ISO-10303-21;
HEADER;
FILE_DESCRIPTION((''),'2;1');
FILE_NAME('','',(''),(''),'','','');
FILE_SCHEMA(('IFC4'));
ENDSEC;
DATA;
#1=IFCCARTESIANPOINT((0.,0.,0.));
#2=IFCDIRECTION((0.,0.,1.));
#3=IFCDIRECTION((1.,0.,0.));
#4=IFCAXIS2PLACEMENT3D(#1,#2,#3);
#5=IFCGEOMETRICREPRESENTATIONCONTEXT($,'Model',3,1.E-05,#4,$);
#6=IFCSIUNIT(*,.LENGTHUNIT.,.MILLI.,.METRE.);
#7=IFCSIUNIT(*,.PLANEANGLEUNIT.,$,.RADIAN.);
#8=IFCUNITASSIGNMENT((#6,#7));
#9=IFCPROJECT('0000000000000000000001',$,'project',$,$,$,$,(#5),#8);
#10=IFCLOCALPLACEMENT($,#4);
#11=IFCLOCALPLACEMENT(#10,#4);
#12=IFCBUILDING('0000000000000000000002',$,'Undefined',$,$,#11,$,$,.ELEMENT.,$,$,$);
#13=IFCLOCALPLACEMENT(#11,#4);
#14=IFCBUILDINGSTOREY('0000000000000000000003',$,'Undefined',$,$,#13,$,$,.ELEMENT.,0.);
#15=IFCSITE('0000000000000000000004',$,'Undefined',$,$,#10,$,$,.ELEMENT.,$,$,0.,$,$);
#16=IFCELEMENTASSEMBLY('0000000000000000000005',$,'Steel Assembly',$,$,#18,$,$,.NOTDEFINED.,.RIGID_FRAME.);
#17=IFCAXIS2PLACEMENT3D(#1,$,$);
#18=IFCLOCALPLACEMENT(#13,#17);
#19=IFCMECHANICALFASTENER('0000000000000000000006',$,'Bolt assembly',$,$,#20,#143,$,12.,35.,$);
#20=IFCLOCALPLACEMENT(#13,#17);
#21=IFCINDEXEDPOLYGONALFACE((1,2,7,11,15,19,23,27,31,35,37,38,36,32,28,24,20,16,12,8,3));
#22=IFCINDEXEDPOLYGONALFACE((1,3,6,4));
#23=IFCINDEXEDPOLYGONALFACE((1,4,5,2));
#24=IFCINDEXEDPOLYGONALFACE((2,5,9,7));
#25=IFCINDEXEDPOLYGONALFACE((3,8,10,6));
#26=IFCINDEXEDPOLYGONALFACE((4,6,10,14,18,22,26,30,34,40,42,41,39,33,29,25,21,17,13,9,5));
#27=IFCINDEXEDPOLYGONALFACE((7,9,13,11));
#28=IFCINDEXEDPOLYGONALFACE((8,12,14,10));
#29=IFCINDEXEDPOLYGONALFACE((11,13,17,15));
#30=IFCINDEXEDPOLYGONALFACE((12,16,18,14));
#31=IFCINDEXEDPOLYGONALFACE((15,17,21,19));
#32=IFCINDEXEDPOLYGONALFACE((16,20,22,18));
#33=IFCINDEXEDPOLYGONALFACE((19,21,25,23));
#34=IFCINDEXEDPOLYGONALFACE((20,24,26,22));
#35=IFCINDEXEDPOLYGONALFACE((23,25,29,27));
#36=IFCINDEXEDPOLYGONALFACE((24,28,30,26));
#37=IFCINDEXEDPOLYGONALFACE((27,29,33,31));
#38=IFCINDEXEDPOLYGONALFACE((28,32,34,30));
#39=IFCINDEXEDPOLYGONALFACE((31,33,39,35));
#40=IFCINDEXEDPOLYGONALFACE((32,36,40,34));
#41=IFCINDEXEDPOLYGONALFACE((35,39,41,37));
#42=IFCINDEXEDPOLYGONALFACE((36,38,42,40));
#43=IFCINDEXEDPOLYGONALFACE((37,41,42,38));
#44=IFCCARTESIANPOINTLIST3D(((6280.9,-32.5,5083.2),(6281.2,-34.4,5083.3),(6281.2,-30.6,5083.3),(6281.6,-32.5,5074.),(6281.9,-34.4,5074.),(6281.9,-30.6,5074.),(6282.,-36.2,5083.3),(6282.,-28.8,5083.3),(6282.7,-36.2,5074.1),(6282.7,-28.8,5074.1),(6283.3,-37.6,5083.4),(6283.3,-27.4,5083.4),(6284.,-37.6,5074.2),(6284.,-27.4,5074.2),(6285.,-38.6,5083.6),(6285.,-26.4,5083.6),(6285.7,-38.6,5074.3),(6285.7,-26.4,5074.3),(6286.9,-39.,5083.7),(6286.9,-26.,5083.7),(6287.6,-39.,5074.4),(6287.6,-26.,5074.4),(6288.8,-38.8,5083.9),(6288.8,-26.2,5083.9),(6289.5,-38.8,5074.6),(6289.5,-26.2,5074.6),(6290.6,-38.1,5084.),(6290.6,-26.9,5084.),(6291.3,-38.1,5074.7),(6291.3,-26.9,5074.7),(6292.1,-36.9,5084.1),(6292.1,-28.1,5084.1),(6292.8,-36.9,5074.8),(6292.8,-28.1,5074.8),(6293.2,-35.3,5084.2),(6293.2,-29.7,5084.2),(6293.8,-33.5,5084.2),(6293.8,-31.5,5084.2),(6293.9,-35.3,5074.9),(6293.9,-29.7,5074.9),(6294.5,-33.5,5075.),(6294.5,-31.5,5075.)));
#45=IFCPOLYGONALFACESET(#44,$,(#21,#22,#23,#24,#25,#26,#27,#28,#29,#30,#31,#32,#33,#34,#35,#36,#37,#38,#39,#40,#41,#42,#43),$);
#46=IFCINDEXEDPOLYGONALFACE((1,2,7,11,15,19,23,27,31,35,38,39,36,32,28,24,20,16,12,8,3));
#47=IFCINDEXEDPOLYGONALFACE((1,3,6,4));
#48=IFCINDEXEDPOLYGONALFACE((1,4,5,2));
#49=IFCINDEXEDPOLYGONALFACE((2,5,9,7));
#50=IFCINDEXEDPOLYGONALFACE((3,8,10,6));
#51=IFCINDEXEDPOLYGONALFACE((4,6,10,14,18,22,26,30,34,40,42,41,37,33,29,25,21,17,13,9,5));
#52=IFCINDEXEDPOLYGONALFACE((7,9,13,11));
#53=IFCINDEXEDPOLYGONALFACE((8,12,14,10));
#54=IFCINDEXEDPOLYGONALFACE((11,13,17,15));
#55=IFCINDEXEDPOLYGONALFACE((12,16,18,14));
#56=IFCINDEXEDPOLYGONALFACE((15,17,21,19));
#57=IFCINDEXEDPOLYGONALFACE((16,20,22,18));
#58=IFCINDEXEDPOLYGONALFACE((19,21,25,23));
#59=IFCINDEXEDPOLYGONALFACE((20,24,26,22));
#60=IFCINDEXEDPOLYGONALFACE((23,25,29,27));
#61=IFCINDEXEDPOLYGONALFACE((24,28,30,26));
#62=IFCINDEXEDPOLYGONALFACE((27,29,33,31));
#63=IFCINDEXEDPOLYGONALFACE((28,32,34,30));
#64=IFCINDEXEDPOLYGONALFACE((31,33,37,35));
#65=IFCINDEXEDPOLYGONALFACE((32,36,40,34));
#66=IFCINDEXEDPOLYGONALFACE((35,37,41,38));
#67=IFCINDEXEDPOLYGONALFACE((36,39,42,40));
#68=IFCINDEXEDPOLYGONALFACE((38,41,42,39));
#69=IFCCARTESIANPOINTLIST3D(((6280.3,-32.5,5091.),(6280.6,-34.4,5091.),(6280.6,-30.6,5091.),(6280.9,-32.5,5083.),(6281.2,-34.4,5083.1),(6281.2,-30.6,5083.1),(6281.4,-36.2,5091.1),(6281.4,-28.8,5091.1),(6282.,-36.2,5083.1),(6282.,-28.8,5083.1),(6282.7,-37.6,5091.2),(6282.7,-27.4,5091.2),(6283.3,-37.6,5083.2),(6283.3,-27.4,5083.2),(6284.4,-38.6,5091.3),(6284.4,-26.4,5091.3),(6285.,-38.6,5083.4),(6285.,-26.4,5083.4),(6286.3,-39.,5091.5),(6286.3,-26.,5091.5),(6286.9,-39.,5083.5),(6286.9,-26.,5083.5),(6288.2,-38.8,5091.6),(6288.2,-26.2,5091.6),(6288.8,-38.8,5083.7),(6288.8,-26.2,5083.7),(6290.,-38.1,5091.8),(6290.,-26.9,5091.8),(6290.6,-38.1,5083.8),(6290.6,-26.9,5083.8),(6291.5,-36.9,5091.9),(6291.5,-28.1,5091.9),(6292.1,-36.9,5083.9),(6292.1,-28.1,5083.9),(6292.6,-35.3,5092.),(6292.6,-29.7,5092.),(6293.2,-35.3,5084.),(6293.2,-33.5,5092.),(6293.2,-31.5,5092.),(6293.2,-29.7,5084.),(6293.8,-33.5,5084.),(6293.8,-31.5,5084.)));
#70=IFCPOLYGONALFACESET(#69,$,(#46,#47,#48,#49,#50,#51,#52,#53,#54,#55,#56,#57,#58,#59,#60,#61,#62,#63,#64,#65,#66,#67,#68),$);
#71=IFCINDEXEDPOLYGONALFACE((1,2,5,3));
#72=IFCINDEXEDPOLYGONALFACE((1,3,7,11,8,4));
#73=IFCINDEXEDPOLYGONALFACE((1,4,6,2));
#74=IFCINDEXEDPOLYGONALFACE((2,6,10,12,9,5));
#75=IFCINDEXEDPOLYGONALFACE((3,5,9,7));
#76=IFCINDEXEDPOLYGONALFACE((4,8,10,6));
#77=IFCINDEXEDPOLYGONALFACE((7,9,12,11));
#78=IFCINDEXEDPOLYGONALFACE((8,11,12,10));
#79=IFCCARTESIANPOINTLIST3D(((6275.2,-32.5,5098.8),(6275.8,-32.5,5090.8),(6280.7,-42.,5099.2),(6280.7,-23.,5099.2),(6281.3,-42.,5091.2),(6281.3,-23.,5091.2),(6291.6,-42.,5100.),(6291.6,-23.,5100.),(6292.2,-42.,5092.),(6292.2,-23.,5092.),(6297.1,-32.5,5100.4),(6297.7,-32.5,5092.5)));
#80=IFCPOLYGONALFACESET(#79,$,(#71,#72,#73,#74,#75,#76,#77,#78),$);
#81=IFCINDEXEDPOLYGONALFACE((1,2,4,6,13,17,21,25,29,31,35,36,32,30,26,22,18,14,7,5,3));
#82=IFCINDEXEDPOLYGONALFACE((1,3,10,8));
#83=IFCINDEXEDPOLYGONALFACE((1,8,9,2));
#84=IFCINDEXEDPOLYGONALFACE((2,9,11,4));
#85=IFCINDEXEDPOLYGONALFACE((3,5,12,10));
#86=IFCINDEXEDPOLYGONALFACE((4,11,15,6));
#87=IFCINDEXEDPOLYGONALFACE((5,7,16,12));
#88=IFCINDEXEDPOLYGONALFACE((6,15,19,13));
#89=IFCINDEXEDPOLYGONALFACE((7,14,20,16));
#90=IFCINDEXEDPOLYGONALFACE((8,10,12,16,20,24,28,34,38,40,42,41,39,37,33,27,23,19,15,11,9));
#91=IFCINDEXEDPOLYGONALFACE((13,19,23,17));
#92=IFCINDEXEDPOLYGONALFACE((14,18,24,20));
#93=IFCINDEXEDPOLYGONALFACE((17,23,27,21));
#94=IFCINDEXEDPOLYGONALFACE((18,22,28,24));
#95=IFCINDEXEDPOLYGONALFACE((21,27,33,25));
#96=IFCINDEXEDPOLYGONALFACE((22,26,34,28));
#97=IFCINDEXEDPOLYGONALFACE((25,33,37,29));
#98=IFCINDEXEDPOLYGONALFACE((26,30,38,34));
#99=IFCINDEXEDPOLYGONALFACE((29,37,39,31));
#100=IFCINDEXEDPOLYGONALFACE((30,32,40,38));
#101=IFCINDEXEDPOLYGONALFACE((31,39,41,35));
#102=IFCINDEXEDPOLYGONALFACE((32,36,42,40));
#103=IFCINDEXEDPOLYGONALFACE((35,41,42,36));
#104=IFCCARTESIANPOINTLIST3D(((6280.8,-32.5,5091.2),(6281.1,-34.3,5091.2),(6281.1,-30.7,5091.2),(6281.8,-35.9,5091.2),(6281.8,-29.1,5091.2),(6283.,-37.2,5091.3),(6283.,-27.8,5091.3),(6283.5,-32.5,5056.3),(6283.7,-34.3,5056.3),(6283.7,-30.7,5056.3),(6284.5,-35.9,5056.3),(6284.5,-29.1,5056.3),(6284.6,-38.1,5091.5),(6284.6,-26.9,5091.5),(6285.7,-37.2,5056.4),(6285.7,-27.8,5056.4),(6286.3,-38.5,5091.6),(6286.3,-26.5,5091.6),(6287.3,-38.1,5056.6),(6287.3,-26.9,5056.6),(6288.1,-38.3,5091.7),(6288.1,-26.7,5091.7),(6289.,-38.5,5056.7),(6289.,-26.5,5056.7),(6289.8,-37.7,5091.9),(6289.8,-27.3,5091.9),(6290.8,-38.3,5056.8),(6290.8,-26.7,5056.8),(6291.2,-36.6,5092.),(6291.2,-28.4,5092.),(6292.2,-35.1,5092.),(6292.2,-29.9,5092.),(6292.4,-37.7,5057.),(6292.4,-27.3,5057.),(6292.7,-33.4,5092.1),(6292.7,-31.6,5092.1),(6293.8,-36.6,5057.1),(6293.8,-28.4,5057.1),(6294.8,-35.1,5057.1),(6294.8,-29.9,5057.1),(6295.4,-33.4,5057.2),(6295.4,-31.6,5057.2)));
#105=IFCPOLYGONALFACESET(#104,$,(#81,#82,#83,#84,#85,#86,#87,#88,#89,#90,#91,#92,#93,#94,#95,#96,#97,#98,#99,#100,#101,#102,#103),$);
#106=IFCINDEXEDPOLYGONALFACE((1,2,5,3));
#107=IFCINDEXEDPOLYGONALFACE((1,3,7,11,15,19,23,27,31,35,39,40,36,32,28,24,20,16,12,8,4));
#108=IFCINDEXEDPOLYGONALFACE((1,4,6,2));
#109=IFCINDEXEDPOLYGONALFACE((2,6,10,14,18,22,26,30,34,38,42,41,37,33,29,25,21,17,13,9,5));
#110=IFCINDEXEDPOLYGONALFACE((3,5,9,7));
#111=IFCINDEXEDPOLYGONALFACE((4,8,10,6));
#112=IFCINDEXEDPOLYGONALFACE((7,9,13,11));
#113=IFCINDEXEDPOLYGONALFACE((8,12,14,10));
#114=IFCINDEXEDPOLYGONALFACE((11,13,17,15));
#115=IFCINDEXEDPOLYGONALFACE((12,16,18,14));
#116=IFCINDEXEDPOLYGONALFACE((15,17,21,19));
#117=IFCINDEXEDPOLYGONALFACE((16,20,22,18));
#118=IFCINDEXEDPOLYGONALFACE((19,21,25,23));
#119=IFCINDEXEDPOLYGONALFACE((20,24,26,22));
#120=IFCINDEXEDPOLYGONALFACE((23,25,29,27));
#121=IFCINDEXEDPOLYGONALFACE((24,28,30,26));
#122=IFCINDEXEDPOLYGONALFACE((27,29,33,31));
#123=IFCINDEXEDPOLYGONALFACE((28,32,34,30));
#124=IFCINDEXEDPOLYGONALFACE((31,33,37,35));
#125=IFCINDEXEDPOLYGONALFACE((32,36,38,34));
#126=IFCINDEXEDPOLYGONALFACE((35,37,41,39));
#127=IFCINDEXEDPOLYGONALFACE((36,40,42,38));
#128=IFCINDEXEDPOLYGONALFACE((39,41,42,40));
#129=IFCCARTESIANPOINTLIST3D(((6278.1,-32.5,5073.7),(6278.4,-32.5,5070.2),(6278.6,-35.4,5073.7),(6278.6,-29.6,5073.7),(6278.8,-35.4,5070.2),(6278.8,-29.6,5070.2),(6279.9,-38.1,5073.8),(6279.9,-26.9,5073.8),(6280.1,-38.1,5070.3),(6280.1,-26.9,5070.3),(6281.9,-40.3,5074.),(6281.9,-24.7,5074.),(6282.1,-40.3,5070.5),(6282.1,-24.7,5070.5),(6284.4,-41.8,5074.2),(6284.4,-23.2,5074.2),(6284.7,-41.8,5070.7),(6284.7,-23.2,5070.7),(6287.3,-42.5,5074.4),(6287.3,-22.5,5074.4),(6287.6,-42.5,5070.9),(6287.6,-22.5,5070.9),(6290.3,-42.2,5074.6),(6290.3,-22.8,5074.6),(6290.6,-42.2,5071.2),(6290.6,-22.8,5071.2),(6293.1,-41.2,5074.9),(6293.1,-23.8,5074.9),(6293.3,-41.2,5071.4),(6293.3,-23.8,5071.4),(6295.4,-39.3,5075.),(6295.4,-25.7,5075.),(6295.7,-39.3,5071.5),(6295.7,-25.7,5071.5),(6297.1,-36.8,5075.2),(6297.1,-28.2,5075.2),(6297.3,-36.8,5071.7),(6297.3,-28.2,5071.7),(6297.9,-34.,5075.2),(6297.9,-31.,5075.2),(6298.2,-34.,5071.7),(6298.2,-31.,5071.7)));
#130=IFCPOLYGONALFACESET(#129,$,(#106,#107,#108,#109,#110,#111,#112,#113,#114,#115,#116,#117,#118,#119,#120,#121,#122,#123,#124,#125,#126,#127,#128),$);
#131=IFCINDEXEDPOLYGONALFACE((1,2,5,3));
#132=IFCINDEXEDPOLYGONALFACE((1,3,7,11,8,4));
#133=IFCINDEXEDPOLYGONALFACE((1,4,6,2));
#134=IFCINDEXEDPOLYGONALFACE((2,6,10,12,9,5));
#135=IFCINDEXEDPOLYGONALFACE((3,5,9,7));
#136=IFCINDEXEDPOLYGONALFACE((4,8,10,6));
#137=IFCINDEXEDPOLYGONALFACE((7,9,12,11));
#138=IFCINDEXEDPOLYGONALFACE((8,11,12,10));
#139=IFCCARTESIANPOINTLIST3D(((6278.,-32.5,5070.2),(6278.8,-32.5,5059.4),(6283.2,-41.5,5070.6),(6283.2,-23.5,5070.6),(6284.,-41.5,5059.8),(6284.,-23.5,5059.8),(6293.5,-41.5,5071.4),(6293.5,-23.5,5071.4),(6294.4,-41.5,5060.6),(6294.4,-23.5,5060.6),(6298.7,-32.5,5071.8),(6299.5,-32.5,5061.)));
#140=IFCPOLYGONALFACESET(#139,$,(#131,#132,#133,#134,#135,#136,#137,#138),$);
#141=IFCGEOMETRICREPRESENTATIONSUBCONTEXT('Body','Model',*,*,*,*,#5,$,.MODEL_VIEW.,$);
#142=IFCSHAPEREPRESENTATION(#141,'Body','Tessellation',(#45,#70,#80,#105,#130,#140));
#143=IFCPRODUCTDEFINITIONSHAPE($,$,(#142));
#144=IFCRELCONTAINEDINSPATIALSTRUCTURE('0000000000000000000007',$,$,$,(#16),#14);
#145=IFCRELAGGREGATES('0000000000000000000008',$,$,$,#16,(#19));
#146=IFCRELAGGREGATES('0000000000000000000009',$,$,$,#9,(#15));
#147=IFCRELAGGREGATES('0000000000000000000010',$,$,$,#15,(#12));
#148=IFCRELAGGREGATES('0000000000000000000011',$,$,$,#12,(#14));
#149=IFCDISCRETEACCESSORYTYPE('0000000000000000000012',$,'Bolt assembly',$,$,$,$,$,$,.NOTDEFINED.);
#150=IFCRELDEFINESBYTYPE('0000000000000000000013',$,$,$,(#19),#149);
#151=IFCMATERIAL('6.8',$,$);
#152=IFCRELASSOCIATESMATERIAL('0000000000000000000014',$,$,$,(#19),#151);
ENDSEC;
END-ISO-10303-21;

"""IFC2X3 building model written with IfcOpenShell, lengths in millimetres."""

from ifc_helpers import new_model, si_unit, frame, origin_with_axes, origin_2d_with_axis, place, context, subcontext, project, spatial, polyline, circle, outline, extrude, source, transform, mapped, material, type_object, element, aggregate, save


model = new_model("IFC2X3")

# Units and contexts
model_context = context("Model", 3, precision=1e-05, world=origin_with_axes())
body_context = subcontext(model_context, "Body", "Model", "MODEL_VIEW")
ifc_project = project(units=[si_unit("LENGTHUNIT", "METRE", prefix="MILLI"), si_unit("PLANEANGLEUNIT", "RADIAN")], contexts=[model_context])

# Site, building, storey
site_placement = place(None, origin_with_axes())
site = spatial("IfcSite", under=ifc_project, at=site_placement, Name="Undefined", CompositionType="ELEMENT", RefElevation=0.0)
building_placement = place(site_placement, origin_with_axes())
building = spatial("IfcBuilding", under=site, at=building_placement, Name="Undefined", CompositionType="ELEMENT")
storey_placement = place(building_placement, origin_with_axes())
storey = spatial("IfcBuildingStorey", under=building, at=storey_placement, Name="Undefined", CompositionType="ELEMENT", Elevation=0.0)

# Element assembly, mechanical fastener
ifc_material_1 = material(Name="6.8")
discrete_accessory_type_1 = type_object("IfcDiscreteAccessoryType", Name="Bolt assembly")
shared_shape_1 = source(origin_with_axes(), body_context, "Body", "SweptSolid", [
    extrude(circle(Radius=6.5, at=origin_2d_with_axis()), frame((0.0, -0.1, 0.0), z_axis=(0.0, 1.0, 0.0), x_axis=(1.0, 0.0, 0.0)), (0.0, 0.0, 1.0), 9.3),
    extrude(circle(Radius=6.5, at=origin_2d_with_axis()), frame((0.0, -7.9, 0.0), z_axis=(0.0, 1.0, 0.0), x_axis=(1.0, 0.0, 0.0)), (0.0, 0.0, 1.0), 8.0),
    extrude(outline(polyline([(11.0, 0.0), (5.5, 9.5), (-5.5, 9.5), (-11.0, 0.0), (-5.5, -9.5), (5.5, -9.5), (11.0, 0.0)])), frame((0.0, -16.0, 0.0), z_axis=(0.0, 1.0, 0.0), x_axis=(1.0, 0.0, 0.0)), (0.0, 0.0, 1.0), 8.0),
    extrude(circle(Radius=6.0, at=origin_2d_with_axis()), frame((0.0, -8.0, 0.0), z_axis=(0.0, 1.0, 0.0), x_axis=(1.0, 0.0, 0.0)), (0.0, 0.0, 1.0), 35.0),
    extrude(circle(Radius=10.0, at=origin_2d_with_axis()), frame((0.0, 9.2, 0.0), z_axis=(0.0, 1.0, 0.0), x_axis=(1.0, 0.0, 0.0)), (0.0, 0.0, 1.0), 3.5),
    extrude(outline(polyline([(10.4, 0.0), (5.2, 9.0), (-5.2, 9.0), (-10.4, 0.0), (-5.2, -9.0), (5.2, -9.0), (10.4, 0.0)])), frame((0.0, 12.7, 0.0), z_axis=(0.0, 1.0, 0.0), x_axis=(1.0, 0.0, 0.0)), (0.0, 0.0, 1.0), 10.8),
])
assembly_1_placement = place(storey_placement, origin_with_axes())
assembly_1 = element("IfcElementAssembly", 1, at=assembly_1_placement, inside=storey, Name="Steel Assembly", AssemblyPlace="NOTDEFINED", PredefinedType="RIGID_FRAME")
mechanical_fastener_1_placement = place(assembly_1_placement, frame((6287.4, -32.5, 5083.6), z_axis=(0.0, -1.0, 0.0), x_axis=(-0.997054, 0.0, -0.076696)))
mechanical_fastener_1 = element("IfcMechanicalFastener", 2, at=mechanical_fastener_1_placement, type_object=discrete_accessory_type_1, material=ifc_material_1, Name="Bolt assembly", NominalDiameter=12.0, NominalLength=35.0, context=body_context, shape_type="MappedRepresentation", body=[
    mapped(shared_shape_1, transform((0.0, 0.0, 0.0))),
])
aggregate(assembly_1, [mechanical_fastener_1])

save(model, "model.ifc")
